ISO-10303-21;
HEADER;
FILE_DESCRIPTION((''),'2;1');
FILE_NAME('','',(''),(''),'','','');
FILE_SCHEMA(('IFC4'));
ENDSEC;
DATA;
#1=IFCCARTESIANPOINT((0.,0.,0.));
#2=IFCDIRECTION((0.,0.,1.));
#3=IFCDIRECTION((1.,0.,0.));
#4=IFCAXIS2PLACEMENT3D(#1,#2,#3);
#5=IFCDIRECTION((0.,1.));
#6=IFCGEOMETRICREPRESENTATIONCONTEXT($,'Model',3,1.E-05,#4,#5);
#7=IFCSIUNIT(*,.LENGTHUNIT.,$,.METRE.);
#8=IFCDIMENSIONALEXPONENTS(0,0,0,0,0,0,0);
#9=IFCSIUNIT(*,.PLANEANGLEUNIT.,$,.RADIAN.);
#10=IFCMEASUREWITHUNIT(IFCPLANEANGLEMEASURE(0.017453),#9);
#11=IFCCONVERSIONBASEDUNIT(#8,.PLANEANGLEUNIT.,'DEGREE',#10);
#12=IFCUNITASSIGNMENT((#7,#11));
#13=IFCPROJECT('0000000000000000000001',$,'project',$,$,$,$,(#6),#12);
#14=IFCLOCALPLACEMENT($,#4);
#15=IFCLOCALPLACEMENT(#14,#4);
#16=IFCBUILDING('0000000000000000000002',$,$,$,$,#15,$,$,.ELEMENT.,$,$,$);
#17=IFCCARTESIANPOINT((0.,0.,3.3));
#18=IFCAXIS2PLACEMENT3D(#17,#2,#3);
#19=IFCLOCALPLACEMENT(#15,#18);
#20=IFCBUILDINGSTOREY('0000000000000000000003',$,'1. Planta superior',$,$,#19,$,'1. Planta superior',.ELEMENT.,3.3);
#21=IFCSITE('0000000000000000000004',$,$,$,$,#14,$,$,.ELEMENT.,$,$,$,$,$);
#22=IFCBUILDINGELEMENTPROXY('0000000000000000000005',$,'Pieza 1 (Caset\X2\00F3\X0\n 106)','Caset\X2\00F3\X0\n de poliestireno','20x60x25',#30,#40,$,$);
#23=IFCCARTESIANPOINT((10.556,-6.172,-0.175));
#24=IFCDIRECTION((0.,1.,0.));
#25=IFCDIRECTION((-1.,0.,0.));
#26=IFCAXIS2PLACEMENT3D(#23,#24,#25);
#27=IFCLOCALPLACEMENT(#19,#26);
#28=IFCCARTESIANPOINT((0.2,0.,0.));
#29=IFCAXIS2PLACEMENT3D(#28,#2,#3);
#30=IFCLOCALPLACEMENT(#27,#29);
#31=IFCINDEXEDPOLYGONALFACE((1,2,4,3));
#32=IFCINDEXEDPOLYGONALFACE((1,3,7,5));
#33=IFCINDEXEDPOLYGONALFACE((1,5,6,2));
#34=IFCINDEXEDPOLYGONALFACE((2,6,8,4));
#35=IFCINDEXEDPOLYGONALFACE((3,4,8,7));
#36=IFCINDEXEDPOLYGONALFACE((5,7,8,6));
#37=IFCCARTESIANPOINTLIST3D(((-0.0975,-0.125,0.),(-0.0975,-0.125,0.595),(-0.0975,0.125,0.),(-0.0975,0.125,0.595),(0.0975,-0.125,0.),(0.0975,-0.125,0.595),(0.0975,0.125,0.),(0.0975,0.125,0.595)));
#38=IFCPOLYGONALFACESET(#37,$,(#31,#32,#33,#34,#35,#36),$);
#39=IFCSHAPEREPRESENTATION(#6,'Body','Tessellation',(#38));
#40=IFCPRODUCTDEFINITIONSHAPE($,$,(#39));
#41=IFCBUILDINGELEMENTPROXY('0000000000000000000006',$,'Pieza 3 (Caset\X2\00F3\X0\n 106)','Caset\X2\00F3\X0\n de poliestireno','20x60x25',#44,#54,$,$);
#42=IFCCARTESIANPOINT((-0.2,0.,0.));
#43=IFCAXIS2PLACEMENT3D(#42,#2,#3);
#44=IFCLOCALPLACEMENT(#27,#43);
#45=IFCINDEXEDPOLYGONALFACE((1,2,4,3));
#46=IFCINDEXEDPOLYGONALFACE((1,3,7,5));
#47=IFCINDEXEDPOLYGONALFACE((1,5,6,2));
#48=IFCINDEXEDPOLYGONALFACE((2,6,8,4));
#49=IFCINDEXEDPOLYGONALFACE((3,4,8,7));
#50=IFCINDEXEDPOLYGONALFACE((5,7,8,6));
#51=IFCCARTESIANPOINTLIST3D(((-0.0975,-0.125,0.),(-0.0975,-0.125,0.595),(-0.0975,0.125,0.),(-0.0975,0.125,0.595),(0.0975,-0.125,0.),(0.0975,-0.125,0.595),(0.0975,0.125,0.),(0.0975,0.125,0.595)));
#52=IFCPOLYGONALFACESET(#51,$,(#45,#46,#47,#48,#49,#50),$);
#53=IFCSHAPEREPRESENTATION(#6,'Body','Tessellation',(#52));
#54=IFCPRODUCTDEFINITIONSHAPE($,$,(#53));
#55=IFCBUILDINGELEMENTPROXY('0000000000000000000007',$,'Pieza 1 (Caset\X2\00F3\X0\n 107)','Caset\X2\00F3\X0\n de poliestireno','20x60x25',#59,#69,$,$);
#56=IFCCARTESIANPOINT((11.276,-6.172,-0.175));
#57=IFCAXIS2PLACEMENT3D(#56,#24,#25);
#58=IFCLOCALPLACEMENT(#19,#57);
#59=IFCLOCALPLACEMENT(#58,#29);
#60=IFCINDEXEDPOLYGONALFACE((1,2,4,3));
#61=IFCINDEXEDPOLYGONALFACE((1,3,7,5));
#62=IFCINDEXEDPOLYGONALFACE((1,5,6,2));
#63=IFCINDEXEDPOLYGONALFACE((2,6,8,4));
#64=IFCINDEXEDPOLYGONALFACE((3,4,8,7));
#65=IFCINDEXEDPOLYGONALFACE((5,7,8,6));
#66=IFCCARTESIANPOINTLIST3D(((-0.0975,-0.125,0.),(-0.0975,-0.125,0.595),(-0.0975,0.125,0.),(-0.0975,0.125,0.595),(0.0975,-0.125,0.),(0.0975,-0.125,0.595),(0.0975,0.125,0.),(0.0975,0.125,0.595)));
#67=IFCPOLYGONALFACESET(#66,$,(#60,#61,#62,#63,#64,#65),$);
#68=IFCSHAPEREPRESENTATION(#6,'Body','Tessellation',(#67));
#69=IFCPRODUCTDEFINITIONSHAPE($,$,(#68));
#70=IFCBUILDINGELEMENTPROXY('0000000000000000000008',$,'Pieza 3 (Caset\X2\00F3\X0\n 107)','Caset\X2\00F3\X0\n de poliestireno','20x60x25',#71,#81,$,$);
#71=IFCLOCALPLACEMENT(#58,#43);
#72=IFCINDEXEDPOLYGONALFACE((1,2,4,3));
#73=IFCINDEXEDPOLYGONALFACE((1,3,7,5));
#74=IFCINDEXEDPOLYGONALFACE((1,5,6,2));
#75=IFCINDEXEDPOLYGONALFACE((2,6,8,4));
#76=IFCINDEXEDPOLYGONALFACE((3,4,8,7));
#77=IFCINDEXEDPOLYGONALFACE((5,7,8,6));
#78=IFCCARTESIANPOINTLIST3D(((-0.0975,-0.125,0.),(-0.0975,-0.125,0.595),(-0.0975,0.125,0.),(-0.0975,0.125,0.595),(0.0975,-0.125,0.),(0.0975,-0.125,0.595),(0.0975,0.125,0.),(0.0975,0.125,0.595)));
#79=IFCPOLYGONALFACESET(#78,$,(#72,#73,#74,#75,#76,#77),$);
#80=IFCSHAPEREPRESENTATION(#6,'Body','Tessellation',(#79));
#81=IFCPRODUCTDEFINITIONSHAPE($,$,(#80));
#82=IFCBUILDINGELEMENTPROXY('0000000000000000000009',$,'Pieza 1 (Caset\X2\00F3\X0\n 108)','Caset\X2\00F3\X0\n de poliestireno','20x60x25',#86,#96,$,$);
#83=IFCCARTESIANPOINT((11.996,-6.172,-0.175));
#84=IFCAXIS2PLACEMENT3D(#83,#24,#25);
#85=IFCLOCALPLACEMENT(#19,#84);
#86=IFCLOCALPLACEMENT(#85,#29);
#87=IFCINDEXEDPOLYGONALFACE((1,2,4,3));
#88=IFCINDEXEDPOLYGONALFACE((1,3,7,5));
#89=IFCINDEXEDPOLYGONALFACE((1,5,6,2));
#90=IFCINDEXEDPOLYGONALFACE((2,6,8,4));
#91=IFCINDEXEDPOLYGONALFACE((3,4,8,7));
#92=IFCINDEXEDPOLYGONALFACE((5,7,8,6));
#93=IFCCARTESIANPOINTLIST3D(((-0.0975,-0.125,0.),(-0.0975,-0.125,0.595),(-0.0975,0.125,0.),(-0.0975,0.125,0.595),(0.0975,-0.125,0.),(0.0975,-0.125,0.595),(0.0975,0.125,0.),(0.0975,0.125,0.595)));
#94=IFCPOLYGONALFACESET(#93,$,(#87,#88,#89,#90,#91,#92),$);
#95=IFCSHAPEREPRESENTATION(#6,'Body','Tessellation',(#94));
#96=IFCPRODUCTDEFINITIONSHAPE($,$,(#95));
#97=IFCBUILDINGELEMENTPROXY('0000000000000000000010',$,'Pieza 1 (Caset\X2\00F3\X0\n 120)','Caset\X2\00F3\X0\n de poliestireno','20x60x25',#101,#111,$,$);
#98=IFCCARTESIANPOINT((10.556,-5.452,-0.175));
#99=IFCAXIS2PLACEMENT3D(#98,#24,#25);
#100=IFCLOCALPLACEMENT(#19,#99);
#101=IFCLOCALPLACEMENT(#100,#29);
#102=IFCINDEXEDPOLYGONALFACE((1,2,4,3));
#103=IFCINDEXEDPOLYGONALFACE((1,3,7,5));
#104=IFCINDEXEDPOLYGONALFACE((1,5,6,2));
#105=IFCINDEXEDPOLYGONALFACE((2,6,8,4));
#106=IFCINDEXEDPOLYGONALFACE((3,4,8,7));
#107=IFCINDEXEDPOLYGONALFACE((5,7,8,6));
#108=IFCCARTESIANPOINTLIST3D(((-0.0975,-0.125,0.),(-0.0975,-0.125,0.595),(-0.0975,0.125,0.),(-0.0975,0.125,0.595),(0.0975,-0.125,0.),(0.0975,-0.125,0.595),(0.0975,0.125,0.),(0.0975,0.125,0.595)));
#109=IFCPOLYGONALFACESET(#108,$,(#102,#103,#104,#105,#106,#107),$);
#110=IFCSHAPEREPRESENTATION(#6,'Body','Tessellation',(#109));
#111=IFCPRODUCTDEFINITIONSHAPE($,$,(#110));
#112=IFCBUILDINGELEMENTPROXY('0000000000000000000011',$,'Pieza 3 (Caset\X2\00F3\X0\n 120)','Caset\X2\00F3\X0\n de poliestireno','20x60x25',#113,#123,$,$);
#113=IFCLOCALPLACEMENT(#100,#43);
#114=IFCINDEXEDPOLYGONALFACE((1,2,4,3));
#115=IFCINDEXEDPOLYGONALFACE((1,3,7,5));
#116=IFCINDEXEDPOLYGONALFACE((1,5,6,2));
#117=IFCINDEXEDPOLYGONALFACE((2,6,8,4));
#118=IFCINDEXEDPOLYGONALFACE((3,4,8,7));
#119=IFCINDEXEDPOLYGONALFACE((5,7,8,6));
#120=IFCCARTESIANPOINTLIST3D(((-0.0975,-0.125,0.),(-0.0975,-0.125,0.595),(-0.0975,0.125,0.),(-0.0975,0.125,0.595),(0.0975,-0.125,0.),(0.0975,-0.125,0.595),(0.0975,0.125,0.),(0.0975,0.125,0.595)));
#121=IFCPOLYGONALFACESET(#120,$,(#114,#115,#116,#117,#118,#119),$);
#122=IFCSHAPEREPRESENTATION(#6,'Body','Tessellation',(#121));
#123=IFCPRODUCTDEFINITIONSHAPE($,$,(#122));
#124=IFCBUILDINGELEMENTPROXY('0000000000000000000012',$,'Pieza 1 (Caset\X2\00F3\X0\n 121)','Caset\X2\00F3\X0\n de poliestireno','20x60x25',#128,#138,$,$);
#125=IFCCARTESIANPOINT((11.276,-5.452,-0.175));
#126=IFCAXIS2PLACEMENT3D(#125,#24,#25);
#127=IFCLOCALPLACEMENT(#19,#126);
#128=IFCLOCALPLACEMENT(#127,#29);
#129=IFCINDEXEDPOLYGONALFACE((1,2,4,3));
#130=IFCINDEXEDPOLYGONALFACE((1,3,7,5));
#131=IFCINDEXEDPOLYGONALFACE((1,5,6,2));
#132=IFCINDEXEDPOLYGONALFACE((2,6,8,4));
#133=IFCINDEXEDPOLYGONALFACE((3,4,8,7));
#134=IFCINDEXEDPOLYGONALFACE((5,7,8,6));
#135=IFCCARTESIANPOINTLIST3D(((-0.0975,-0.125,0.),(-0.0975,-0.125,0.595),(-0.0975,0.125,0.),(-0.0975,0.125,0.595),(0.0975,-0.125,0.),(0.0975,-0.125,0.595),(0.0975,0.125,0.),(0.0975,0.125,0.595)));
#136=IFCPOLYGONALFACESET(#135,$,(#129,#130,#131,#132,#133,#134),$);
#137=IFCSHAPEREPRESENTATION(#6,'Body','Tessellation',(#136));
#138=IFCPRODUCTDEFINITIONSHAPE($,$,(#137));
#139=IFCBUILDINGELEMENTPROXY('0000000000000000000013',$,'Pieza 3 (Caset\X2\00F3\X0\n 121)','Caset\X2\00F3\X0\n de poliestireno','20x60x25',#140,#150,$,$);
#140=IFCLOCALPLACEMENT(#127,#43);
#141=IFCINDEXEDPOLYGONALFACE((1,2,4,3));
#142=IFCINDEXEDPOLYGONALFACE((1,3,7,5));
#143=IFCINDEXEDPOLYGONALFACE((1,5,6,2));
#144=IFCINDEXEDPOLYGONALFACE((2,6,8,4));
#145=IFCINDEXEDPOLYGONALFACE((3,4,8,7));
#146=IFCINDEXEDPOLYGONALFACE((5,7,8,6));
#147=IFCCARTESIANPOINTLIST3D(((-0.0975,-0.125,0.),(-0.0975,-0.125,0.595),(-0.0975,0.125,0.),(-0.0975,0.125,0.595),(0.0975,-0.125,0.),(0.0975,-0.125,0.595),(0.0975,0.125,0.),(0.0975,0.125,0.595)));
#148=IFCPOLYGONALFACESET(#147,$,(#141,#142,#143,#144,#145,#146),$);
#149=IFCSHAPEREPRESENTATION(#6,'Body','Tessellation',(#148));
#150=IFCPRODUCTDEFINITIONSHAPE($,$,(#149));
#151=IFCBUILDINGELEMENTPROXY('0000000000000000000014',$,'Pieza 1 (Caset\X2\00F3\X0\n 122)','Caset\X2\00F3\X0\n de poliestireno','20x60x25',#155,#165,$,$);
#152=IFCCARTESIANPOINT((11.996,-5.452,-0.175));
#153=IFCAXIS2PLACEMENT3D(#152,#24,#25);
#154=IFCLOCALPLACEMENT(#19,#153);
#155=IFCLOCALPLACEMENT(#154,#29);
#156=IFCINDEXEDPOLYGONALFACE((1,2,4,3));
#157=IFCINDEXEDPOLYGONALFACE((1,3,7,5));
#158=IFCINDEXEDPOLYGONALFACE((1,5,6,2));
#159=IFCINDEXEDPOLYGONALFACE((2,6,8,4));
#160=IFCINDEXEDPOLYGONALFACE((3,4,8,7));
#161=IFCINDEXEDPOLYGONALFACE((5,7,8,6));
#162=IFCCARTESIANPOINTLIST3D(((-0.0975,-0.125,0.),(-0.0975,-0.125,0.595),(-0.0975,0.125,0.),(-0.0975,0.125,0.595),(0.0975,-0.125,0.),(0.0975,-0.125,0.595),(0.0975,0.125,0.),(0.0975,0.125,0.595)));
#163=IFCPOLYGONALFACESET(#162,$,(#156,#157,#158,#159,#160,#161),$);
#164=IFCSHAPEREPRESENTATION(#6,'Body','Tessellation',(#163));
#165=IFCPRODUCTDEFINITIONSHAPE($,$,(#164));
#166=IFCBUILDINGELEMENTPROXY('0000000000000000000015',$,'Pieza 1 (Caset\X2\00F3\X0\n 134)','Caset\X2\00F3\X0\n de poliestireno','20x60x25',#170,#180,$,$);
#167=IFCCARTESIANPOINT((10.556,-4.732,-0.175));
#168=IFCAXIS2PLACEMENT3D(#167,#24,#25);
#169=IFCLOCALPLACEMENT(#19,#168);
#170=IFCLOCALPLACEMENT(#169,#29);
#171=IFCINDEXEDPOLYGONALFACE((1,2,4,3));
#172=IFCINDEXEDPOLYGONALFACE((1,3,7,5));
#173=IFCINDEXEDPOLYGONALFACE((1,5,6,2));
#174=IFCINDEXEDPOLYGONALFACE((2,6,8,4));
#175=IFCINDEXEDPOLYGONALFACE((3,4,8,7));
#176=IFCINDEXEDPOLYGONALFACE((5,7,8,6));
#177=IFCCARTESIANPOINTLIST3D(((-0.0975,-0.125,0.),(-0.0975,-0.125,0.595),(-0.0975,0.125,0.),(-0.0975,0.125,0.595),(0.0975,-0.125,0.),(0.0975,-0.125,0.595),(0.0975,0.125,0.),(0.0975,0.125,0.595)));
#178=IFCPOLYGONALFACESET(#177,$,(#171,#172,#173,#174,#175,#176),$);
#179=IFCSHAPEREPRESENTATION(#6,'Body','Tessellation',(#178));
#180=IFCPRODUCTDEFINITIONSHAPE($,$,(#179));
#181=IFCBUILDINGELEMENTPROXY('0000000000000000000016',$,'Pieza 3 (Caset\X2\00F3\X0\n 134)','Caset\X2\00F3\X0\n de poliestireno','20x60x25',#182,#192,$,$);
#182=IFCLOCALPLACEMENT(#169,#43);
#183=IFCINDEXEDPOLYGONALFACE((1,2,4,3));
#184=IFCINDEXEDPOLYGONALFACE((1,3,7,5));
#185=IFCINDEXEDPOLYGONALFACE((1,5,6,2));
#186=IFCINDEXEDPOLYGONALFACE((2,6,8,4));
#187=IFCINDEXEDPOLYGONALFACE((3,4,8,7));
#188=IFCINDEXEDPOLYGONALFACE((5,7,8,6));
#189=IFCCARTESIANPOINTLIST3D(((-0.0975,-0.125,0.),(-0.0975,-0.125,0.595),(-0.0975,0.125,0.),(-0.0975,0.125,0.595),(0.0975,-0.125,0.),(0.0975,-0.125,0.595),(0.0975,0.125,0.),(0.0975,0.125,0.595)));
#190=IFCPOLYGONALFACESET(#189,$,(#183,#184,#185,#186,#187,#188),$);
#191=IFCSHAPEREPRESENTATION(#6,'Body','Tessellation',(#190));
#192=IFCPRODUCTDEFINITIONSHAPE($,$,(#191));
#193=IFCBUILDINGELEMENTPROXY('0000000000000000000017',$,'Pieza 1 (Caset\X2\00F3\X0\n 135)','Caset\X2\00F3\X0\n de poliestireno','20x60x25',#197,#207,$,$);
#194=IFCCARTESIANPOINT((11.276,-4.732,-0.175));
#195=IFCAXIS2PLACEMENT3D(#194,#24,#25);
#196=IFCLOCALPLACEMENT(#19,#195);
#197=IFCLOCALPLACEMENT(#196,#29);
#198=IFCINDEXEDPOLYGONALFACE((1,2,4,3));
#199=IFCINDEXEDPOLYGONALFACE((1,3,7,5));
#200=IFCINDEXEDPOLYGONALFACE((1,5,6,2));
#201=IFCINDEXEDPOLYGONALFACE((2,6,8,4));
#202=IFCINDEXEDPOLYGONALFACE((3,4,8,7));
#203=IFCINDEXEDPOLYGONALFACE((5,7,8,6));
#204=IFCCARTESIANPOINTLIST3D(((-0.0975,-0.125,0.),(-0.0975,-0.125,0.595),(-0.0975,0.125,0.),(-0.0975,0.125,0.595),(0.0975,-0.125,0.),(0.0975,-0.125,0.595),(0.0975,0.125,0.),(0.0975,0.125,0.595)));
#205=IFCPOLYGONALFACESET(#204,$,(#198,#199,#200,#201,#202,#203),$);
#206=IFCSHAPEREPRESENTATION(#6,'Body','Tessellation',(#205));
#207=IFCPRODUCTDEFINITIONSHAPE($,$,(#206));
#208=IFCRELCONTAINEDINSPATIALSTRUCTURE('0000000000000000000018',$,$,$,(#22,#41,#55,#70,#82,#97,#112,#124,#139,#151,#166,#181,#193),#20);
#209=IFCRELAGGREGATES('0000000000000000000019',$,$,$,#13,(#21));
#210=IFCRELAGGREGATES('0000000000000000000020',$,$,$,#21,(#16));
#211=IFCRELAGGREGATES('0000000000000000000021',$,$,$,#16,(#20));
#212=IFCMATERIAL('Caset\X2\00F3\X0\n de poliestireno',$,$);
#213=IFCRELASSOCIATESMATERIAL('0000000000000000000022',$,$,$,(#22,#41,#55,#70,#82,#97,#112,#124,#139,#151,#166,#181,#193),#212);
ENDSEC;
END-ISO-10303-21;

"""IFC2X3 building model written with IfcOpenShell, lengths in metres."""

from ifc_helpers import new_model, entity, si_unit, converted_unit, direction, frame, origin_with_axes, origin_2d_with_axis, place, context, project, spatial, rectangle, extrude, source, transform, mapped, material, element, save


model = new_model("IFC2X3")

# Units and contexts
model_context = context("Model", 3, precision=1e-05, world=origin_with_axes(), true_north=direction((0.0, 1.0)))
ifc_project = project(units=[si_unit("LENGTHUNIT", "METRE"), converted_unit("PLANEANGLEUNIT", "DEGREE", entity("IfcPlaneAngleMeasure", 0.017453), si_unit("PLANEANGLEUNIT", "RADIAN"), dimensions=[0, 0, 0, 0, 0, 0, 0])], contexts=[model_context])

# Site, building, storey
site_placement = place(None, origin_with_axes())
site = spatial("IfcSite", under=ifc_project, at=site_placement, CompositionType="ELEMENT")
building_placement = place(site_placement, origin_with_axes())
building = spatial("IfcBuilding", under=site, at=building_placement, CompositionType="ELEMENT")
storey_placement = place(building_placement, frame((0.0, 0.0, 3.3), z_axis=(0.0, 0.0, 1.0), x_axis=(1.0, 0.0, 0.0)))
storey = spatial("IfcBuildingStorey", under=building, at=storey_placement, Name="1. Planta superior", LongName="1. Planta superior", CompositionType="ELEMENT", Elevation=3.3)

# Building element proxies
ifc_material = material(Name="Casetón de poliestireno")
shared_shape = source(origin_with_axes(), model_context, "Body", "SweptSolid", [
    extrude(rectangle(XDim=0.195, YDim=0.25, at=origin_2d_with_axis()), origin_with_axes(), (0.0, 0.0, 1.0), 0.595),
])
placement_1 = place(storey_placement, frame((10.556, -6.172, -0.175), z_axis=(0.0, 1.0, 0.0), x_axis=(-1.0, 0.0, 0.0)))
for number, where, z_axis, x_axis, name in (
    (1, (0.2, 0.0, 0.0), (0.0, 0.0, 1.0), (1.0, 0.0, 0.0), "Pieza 1 (Casetón 106)"),
    (2, (-0.2, 0.0, 0.0), (0.0, 0.0, 1.0), (1.0, 0.0, 0.0), "Pieza 3 (Casetón 106)"),
):
    element("IfcBuildingElementProxy", number, at=place(placement_1, frame(where, z_axis=z_axis, x_axis=x_axis)), inside=storey, material=ifc_material, Name=name, Description="Casetón de poliestireno", ObjectType="20x60x25", context=model_context, shape_type="MappedRepresentation", body=[
        mapped(shared_shape, transform((0.0, 0.0, 0.0), x_axis=(1.0, 0.0, 0.0), y_axis=(0.0, 1.0, 0.0), z_axis=(0.0, 0.0, 1.0))),
    ])
placement_2 = place(storey_placement, frame((11.276, -6.172, -0.175), z_axis=(0.0, 1.0, 0.0), x_axis=(-1.0, 0.0, 0.0)))
for number, where, z_axis, x_axis, name in (
    (3, (0.2, 0.0, 0.0), (0.0, 0.0, 1.0), (1.0, 0.0, 0.0), "Pieza 1 (Casetón 107)"),
    (4, (-0.2, 0.0, 0.0), (0.0, 0.0, 1.0), (1.0, 0.0, 0.0), "Pieza 3 (Casetón 107)"),
):
    element("IfcBuildingElementProxy", number, at=place(placement_2, frame(where, z_axis=z_axis, x_axis=x_axis)), inside=storey, material=ifc_material, Name=name, Description="Casetón de poliestireno", ObjectType="20x60x25", context=model_context, shape_type="MappedRepresentation", body=[
        mapped(shared_shape, transform((0.0, 0.0, 0.0), x_axis=(1.0, 0.0, 0.0), y_axis=(0.0, 1.0, 0.0), z_axis=(0.0, 0.0, 1.0))),
    ])
placement_3 = place(storey_placement, frame((11.996, -6.172, -0.175), z_axis=(0.0, 1.0, 0.0), x_axis=(-1.0, 0.0, 0.0)))
for number, where, z_axis, x_axis, name in (
    (5, (0.2, 0.0, 0.0), (0.0, 0.0, 1.0), (1.0, 0.0, 0.0), "Pieza 1 (Casetón 108)"),
):
    element("IfcBuildingElementProxy", number, at=place(placement_3, frame(where, z_axis=z_axis, x_axis=x_axis)), inside=storey, material=ifc_material, Name=name, Description="Casetón de poliestireno", ObjectType="20x60x25", context=model_context, shape_type="MappedRepresentation", body=[
        mapped(shared_shape, transform((0.0, 0.0, 0.0), x_axis=(1.0, 0.0, 0.0), y_axis=(0.0, 1.0, 0.0), z_axis=(0.0, 0.0, 1.0))),
    ])
placement_4 = place(storey_placement, frame((10.556, -5.452, -0.175), z_axis=(0.0, 1.0, 0.0), x_axis=(-1.0, 0.0, 0.0)))
for number, where, z_axis, x_axis, name in (
    (6, (0.2, 0.0, 0.0), (0.0, 0.0, 1.0), (1.0, 0.0, 0.0), "Pieza 1 (Casetón 120)"),
    (7, (-0.2, 0.0, 0.0), (0.0, 0.0, 1.0), (1.0, 0.0, 0.0), "Pieza 3 (Casetón 120)"),
):
    element("IfcBuildingElementProxy", number, at=place(placement_4, frame(where, z_axis=z_axis, x_axis=x_axis)), inside=storey, material=ifc_material, Name=name, Description="Casetón de poliestireno", ObjectType="20x60x25", context=model_context, shape_type="MappedRepresentation", body=[
        mapped(shared_shape, transform((0.0, 0.0, 0.0), x_axis=(1.0, 0.0, 0.0), y_axis=(0.0, 1.0, 0.0), z_axis=(0.0, 0.0, 1.0))),
    ])
placement_5 = place(storey_placement, frame((11.276, -5.452, -0.175), z_axis=(0.0, 1.0, 0.0), x_axis=(-1.0, 0.0, 0.0)))
for number, where, z_axis, x_axis, name in (
    (8, (0.2, 0.0, 0.0), (0.0, 0.0, 1.0), (1.0, 0.0, 0.0), "Pieza 1 (Casetón 121)"),
    (9, (-0.2, 0.0, 0.0), (0.0, 0.0, 1.0), (1.0, 0.0, 0.0), "Pieza 3 (Casetón 121)"),
):
    element("IfcBuildingElementProxy", number, at=place(placement_5, frame(where, z_axis=z_axis, x_axis=x_axis)), inside=storey, material=ifc_material, Name=name, Description="Casetón de poliestireno", ObjectType="20x60x25", context=model_context, shape_type="MappedRepresentation", body=[
        mapped(shared_shape, transform((0.0, 0.0, 0.0), x_axis=(1.0, 0.0, 0.0), y_axis=(0.0, 1.0, 0.0), z_axis=(0.0, 0.0, 1.0))),
    ])
placement_6 = place(storey_placement, frame((11.996, -5.452, -0.175), z_axis=(0.0, 1.0, 0.0), x_axis=(-1.0, 0.0, 0.0)))
for number, where, z_axis, x_axis, name in (
    (10, (0.2, 0.0, 0.0), (0.0, 0.0, 1.0), (1.0, 0.0, 0.0), "Pieza 1 (Casetón 122)"),
):
    element("IfcBuildingElementProxy", number, at=place(placement_6, frame(where, z_axis=z_axis, x_axis=x_axis)), inside=storey, material=ifc_material, Name=name, Description="Casetón de poliestireno", ObjectType="20x60x25", context=model_context, shape_type="MappedRepresentation", body=[
        mapped(shared_shape, transform((0.0, 0.0, 0.0), x_axis=(1.0, 0.0, 0.0), y_axis=(0.0, 1.0, 0.0), z_axis=(0.0, 0.0, 1.0))),
    ])
placement_7 = place(storey_placement, frame((10.556, -4.732, -0.175), z_axis=(0.0, 1.0, 0.0), x_axis=(-1.0, 0.0, 0.0)))
for number, where, z_axis, x_axis, name in (
    (11, (0.2, 0.0, 0.0), (0.0, 0.0, 1.0), (1.0, 0.0, 0.0), "Pieza 1 (Casetón 134)"),
    (12, (-0.2, 0.0, 0.0), (0.0, 0.0, 1.0), (1.0, 0.0, 0.0), "Pieza 3 (Casetón 134)"),
):
    element("IfcBuildingElementProxy", number, at=place(placement_7, frame(where, z_axis=z_axis, x_axis=x_axis)), inside=storey, material=ifc_material, Name=name, Description="Casetón de poliestireno", ObjectType="20x60x25", context=model_context, shape_type="MappedRepresentation", body=[
        mapped(shared_shape, transform((0.0, 0.0, 0.0), x_axis=(1.0, 0.0, 0.0), y_axis=(0.0, 1.0, 0.0), z_axis=(0.0, 0.0, 1.0))),
    ])
placement_8 = place(storey_placement, frame((11.276, -4.732, -0.175), z_axis=(0.0, 1.0, 0.0), x_axis=(-1.0, 0.0, 0.0)))
for number, where, z_axis, x_axis, name in (
    (13, (0.2, 0.0, 0.0), (0.0, 0.0, 1.0), (1.0, 0.0, 0.0), "Pieza 1 (Casetón 135)"),
):
    element("IfcBuildingElementProxy", number, at=place(placement_8, frame(where, z_axis=z_axis, x_axis=x_axis)), inside=storey, material=ifc_material, Name=name, Description="Casetón de poliestireno", ObjectType="20x60x25", context=model_context, shape_type="MappedRepresentation", body=[
        mapped(shared_shape, transform((0.0, 0.0, 0.0), x_axis=(1.0, 0.0, 0.0), y_axis=(0.0, 1.0, 0.0), z_axis=(0.0, 0.0, 1.0))),
    ])

save(model, "model.ifc")
